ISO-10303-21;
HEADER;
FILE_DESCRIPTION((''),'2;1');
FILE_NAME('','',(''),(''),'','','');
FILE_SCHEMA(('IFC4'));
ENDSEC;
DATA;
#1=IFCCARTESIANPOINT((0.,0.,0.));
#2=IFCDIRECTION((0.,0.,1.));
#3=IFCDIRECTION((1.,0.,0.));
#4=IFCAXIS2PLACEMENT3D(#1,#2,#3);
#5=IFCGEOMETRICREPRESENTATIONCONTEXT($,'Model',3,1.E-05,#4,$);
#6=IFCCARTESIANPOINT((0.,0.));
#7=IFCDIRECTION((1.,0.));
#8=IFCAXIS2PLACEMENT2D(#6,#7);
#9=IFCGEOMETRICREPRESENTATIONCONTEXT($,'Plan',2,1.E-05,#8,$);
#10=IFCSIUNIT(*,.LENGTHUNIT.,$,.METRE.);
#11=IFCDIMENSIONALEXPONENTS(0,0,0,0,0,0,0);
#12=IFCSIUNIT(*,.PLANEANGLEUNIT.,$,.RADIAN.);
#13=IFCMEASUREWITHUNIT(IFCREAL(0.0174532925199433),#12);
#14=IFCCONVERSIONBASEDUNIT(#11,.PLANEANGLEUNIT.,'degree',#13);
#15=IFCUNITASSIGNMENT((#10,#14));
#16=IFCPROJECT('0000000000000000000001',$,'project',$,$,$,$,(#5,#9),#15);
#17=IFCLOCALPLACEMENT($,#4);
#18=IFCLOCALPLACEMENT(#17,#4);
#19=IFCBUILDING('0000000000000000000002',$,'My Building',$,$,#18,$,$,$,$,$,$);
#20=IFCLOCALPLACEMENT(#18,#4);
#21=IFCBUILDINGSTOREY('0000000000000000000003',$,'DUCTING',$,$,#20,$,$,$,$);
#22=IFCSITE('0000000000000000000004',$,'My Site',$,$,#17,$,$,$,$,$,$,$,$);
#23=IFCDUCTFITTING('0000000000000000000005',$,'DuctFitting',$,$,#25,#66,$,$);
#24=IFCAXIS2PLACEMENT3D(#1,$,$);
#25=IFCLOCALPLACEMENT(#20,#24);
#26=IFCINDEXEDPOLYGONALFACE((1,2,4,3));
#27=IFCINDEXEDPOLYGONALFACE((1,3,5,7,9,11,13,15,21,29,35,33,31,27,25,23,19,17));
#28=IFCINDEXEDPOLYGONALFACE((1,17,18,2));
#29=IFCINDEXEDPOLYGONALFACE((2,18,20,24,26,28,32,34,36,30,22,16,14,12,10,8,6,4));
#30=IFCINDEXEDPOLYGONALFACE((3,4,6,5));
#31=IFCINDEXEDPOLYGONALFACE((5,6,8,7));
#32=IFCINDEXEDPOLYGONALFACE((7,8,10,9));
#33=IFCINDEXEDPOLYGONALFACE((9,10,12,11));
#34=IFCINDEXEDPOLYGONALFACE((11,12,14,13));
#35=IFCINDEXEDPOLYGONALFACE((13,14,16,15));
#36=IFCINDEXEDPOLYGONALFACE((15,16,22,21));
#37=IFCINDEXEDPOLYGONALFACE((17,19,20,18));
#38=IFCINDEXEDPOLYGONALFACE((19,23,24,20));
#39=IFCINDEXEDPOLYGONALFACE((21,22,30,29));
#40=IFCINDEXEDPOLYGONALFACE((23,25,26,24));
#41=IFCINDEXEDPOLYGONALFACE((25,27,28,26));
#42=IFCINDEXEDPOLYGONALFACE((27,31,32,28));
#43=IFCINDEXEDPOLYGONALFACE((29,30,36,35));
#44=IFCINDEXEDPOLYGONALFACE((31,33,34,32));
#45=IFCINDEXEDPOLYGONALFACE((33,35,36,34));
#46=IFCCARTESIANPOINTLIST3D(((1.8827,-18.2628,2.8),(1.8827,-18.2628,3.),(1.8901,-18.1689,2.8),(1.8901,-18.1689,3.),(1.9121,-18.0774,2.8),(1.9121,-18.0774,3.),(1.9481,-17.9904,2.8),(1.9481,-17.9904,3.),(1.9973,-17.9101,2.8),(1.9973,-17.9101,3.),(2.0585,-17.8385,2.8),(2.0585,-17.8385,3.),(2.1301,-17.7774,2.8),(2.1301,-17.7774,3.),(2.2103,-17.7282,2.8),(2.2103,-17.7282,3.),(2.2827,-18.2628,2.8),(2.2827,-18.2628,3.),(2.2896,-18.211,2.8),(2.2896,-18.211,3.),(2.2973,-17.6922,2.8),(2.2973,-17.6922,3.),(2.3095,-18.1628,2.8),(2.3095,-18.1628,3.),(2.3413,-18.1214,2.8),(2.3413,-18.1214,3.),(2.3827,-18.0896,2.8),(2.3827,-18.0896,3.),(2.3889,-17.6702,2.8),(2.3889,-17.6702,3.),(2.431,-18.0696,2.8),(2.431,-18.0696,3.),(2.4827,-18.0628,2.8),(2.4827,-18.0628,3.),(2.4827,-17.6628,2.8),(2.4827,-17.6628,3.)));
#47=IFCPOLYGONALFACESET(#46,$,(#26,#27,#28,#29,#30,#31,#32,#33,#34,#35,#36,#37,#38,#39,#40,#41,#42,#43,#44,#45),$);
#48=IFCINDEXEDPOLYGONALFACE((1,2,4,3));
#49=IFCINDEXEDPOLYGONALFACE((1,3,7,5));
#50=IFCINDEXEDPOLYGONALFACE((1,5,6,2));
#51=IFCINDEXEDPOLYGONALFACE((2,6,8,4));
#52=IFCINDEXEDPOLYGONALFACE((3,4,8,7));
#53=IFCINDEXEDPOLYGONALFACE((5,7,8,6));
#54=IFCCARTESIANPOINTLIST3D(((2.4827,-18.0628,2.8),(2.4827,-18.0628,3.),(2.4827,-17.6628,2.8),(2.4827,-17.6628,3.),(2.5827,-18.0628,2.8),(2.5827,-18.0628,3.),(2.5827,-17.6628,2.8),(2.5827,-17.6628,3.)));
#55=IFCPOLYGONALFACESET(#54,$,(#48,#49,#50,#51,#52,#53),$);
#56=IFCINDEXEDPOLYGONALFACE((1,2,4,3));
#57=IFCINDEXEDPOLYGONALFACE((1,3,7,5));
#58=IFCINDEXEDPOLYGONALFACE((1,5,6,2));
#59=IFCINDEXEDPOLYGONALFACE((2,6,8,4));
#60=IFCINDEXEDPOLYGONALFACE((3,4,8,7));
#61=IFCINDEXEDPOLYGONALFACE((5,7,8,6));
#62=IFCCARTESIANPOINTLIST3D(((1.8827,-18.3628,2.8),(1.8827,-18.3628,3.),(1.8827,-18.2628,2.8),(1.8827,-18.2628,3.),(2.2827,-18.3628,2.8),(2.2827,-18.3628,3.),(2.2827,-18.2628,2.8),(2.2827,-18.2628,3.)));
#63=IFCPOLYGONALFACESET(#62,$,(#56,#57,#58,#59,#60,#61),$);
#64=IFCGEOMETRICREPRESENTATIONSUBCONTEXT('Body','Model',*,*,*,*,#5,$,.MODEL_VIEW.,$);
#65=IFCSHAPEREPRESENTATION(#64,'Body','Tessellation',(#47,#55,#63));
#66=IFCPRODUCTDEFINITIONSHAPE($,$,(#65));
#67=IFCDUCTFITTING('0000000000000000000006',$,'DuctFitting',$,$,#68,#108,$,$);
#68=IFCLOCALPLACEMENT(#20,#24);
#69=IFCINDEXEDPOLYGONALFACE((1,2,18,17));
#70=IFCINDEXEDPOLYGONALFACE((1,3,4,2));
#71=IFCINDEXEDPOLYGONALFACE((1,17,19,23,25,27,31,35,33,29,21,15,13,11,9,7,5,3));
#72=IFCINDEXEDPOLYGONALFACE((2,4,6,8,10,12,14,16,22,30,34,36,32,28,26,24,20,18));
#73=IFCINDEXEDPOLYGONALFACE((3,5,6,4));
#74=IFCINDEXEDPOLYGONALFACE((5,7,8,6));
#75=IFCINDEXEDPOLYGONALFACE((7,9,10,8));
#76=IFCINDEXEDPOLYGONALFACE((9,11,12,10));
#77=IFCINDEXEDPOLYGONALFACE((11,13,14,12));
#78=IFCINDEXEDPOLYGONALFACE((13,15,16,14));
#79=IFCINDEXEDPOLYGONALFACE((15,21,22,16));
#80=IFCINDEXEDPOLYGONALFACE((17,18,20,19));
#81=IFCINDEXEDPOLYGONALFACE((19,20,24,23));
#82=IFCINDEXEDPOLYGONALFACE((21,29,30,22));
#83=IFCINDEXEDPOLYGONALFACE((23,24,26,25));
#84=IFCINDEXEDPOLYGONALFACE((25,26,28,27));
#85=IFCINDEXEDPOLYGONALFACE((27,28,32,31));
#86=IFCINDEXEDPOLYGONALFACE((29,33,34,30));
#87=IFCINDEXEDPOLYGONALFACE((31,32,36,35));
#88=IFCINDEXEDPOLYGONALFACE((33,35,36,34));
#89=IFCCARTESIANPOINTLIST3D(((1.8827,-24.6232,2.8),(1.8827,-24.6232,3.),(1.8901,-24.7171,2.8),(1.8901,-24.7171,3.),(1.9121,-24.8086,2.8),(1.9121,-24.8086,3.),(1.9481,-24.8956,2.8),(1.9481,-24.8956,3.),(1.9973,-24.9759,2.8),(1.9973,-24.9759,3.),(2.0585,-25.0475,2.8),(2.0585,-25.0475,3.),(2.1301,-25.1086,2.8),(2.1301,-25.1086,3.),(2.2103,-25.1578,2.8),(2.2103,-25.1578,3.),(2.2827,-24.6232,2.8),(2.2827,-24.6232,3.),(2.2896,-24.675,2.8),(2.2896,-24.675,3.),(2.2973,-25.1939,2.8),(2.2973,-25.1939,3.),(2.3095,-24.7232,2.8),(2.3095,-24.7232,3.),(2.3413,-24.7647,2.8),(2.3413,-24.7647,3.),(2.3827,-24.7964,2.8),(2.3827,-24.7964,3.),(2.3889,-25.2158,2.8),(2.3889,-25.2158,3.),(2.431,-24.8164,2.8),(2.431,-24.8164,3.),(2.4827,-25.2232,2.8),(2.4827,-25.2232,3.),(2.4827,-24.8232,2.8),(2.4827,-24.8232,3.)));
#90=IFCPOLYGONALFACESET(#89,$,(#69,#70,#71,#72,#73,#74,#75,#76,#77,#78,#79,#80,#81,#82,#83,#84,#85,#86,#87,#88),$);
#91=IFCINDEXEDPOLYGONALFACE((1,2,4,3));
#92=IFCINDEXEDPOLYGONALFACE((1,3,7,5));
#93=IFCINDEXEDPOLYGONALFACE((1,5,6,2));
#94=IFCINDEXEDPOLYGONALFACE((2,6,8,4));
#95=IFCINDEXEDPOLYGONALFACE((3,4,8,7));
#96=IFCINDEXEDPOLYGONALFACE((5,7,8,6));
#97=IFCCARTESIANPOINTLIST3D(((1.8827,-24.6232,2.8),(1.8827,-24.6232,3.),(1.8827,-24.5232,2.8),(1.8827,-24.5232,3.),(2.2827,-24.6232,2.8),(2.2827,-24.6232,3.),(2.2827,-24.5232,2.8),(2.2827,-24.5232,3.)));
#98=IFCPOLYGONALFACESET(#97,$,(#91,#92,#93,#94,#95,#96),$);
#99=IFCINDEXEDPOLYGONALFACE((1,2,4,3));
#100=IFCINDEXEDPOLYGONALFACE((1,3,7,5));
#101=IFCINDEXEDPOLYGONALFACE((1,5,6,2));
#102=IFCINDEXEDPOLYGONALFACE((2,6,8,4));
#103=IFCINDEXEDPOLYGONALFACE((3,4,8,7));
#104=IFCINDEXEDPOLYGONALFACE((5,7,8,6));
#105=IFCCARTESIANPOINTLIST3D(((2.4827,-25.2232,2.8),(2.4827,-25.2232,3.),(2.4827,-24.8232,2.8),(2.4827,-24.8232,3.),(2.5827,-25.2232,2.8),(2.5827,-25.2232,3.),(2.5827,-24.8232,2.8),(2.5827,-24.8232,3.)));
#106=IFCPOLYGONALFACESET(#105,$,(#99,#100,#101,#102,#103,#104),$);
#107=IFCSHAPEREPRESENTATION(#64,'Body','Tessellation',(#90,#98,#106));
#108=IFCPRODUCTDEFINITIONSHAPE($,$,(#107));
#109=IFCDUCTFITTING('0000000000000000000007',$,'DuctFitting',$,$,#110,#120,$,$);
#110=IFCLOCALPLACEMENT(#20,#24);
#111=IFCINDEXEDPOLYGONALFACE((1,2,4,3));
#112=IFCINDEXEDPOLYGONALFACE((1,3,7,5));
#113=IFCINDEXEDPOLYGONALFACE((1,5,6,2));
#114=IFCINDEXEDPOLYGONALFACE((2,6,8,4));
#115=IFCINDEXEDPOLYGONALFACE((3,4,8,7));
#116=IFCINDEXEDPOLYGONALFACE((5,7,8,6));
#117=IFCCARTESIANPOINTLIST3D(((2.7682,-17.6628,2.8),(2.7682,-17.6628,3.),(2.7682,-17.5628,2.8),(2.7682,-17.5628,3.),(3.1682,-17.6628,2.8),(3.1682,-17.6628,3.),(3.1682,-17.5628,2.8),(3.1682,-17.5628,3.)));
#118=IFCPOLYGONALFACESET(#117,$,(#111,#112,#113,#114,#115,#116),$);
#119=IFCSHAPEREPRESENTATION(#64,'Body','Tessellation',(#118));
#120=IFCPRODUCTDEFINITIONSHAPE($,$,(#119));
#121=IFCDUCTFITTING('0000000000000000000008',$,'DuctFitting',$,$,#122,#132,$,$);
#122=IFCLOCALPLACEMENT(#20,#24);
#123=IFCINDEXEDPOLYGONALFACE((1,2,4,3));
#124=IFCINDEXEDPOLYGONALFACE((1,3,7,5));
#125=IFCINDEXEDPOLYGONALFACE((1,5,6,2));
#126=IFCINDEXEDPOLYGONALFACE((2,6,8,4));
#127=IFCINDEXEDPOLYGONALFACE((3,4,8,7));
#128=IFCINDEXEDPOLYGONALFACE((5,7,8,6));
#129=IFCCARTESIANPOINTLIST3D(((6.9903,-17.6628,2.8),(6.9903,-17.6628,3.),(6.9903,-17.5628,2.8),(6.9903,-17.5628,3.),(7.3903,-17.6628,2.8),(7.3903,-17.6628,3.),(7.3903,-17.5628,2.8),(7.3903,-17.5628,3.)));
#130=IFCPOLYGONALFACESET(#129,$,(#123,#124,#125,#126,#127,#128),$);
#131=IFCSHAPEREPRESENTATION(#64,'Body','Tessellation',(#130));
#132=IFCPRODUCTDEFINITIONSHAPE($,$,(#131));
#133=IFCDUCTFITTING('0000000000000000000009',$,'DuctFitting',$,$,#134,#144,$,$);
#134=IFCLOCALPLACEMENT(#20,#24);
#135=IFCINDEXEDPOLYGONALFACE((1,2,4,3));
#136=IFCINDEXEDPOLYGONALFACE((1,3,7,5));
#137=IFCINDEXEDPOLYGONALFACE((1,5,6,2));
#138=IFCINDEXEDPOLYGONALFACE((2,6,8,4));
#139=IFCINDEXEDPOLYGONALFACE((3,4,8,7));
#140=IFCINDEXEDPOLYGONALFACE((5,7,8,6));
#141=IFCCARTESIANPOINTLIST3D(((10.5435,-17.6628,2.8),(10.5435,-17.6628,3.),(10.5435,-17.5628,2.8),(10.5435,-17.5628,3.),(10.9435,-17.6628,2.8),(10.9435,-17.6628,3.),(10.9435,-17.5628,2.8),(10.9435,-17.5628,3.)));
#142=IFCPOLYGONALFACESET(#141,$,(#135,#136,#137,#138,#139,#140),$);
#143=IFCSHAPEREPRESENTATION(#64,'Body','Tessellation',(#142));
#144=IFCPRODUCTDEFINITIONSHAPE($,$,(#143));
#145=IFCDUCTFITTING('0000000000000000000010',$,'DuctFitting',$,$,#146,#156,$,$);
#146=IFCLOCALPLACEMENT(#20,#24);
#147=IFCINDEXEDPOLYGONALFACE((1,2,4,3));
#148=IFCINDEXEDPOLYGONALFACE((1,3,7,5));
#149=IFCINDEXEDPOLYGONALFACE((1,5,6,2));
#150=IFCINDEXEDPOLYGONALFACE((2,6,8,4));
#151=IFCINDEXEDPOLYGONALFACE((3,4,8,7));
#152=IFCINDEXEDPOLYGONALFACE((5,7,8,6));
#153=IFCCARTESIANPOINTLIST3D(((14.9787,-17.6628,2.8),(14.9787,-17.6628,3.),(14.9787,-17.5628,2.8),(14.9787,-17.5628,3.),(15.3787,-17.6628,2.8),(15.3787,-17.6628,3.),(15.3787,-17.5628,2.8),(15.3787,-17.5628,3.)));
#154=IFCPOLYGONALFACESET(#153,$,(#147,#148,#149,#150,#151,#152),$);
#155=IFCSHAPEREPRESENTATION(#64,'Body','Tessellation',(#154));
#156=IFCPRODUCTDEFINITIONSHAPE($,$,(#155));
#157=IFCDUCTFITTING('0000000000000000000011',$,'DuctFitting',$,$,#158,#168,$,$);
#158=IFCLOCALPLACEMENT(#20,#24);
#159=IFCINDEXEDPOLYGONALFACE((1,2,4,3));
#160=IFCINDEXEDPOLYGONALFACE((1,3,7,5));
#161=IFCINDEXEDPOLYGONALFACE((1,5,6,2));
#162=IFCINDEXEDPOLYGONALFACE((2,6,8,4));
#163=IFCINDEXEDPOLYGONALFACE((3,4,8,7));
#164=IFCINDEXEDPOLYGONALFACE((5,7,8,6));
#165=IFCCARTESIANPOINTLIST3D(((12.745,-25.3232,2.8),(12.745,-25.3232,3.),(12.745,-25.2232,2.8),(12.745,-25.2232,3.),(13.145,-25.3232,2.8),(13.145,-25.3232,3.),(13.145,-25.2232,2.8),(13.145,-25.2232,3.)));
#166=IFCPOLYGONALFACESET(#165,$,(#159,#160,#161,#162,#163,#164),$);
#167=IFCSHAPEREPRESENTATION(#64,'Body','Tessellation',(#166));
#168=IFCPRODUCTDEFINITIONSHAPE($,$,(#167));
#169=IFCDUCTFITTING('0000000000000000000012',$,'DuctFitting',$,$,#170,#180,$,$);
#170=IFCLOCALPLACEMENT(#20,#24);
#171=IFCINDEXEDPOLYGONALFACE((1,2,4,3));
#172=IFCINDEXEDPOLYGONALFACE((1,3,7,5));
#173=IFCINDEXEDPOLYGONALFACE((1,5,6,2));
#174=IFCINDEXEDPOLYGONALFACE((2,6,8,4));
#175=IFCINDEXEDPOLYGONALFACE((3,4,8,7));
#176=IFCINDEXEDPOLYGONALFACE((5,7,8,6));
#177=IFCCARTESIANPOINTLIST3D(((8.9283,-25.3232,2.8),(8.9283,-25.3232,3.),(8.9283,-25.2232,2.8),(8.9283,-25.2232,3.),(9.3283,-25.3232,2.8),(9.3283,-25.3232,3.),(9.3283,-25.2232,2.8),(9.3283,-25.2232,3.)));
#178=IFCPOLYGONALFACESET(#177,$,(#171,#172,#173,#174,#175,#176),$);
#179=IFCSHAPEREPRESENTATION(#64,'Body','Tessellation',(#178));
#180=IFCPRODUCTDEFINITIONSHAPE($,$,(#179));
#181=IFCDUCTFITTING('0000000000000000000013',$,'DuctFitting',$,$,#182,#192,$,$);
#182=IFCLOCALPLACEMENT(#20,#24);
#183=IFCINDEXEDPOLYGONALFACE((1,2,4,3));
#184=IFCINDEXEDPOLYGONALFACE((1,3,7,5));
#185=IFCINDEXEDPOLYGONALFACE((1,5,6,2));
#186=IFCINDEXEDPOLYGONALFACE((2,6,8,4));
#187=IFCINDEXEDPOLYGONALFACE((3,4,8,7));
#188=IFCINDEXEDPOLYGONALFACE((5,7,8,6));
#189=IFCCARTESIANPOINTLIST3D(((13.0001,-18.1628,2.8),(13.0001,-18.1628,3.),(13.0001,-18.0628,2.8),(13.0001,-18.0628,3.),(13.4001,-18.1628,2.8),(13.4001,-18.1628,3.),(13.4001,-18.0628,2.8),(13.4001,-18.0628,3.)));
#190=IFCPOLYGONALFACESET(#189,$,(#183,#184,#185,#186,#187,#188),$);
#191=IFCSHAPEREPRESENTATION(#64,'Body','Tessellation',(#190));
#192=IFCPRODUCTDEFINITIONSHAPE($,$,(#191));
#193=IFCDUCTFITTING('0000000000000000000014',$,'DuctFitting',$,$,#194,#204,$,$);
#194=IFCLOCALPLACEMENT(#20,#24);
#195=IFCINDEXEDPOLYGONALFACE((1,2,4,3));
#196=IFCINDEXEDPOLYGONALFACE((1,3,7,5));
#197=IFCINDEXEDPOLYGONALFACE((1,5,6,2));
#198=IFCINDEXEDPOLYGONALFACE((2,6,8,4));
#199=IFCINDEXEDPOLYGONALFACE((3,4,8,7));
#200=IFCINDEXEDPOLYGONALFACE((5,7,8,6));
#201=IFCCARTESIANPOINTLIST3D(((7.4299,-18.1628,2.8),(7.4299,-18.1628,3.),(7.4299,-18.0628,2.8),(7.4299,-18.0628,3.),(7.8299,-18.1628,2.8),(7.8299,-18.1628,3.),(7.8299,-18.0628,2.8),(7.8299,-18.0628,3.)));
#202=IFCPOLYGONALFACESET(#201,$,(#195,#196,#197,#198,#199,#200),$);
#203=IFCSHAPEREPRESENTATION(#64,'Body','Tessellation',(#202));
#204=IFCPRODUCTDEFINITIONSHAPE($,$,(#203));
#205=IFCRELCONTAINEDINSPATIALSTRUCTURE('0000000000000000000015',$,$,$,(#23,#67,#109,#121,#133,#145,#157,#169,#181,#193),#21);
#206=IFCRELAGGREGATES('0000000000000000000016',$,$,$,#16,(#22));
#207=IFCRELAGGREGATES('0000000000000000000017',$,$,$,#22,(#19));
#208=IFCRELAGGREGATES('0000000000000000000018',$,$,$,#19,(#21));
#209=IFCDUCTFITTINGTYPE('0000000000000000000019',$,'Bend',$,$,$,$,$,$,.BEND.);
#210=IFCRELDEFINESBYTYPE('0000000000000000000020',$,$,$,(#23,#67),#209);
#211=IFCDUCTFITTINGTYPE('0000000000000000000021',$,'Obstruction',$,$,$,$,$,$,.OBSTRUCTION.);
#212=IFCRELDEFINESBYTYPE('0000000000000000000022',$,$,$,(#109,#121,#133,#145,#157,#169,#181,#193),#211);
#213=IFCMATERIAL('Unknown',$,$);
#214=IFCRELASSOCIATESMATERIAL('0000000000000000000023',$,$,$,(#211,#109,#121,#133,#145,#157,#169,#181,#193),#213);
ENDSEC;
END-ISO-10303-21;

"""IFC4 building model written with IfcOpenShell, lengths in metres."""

from ifc_helpers import new_model, entity, si_unit, converted_unit, frame, origin_with_axes, origin_2d_with_axis, place, context, subcontext, project, spatial, line, arc, indexed_curve, rectangle, outline, extrude, source, transform, mapped, material, material_profile, profile_set, profile_usage, type_object, type_shapes, element, save


model = new_model("IFC4")

# Units and contexts
model_context = context("Model", 3, precision=1e-05, world=origin_with_axes())
plan_context = context("Plan", 2, precision=1e-05, world=origin_2d_with_axis())
body_context = subcontext(model_context, "Body", "Model", "MODEL_VIEW")
ifc_project = project(units=[si_unit("LENGTHUNIT", "METRE"), converted_unit("PLANEANGLEUNIT", "degree", entity("IfcReal", 0.0174532925199433), si_unit("PLANEANGLEUNIT", "RADIAN"), dimensions=[0, 0, 0, 0, 0, 0, 0])], contexts=[model_context, plan_context])

# Site, building, storey
site_placement = place(None, origin_with_axes())
site = spatial("IfcSite", under=ifc_project, at=site_placement, Name="My Site")
building_placement = place(site_placement, origin_with_axes())
building = spatial("IfcBuilding", under=site, at=building_placement, Name="My Building")
storey_placement = place(building_placement, origin_with_axes())
storey = spatial("IfcBuildingStorey", under=building, at=storey_placement, Name="DUCTING")

# Shared definitions
ifc_material = material(Name="Unknown")

# Duct fittings
duct_fitting_type_1 = type_object("IfcDuctFittingType", Name="Bend", PredefinedType="BEND")
shared_shape = source(origin_with_axes(), body_context, "Body", "SweptSolid", [
    extrude(outline(indexed_curve([(-0.2, 0.0), (-0.2586, -0.1414), (-0.4, -0.2), (-0.4, -0.6), (0.0243, -0.4243), (0.2, 0.0)], segments=[arc(1, 2, 3), line(3, 4), arc(4, 5, 6), line(6, 1)])), frame((0.0, -0.1, -0.1), z_axis=(0.0, -1.0, 0.0), x_axis=(1.0, 0.0, 0.0)), (0.0, 0.0, -1.0), 0.2),
    extrude(rectangle(XDim=0.4, YDim=0.2), origin_with_axes(), (0.0, 0.0, -1.0), 0.1),
    extrude(rectangle(XDim=0.4, YDim=0.2), frame((-0.4, 0.0, -0.5), z_axis=(-1.0, 0.0, 0.0), x_axis=(0.0, 0.0, -1.0)), (0.0, 0.0, 1.0), 0.1),
])
type_shapes(duct_fitting_type_1, [shared_shape])
for number, where, z_axis, x_axis, name in (
    (1, (2.5827, -17.8628, 2.9), (1.0, 0.0, 0.0), (0.0, 1.0, 0.0), "DuctFitting"),
    (2, (2.0827, -24.5232, 2.9), (0.0, 1.0, 0.0), (-1.0, 0.0, 0.0), "DuctFitting"),
):
    element("IfcDuctFitting", number, at=place(storey_placement, frame(where, z_axis=z_axis, x_axis=x_axis)), inside=storey, type_object=duct_fitting_type_1, Name=name, context=body_context, shape_type="MappedRepresentation", body=[
        mapped(shared_shape, transform((0.0, 0.0, 0.0), x_axis=(1.0, 0.0, 0.0), y_axis=(0.0, 1.0, 0.0), z_axis=(0.0, 0.0, 1.0), scale=1.0)),
    ])
ifc_material_profile_1 = material_profile(ifc_material, rectangle(XDim=0.4, YDim=0.2))
ifc_profile_set_1 = profile_set([ifc_material_profile_1])
ifc_profile_usage_1 = profile_usage(ifc_profile_set_1, cardinal=5)
duct_fitting_type_2 = type_object("IfcDuctFittingType", Name="Obstruction", PredefinedType="OBSTRUCTION", material=ifc_profile_set_1)
duct_fitting_1_placement = place(storey_placement, frame((2.9682, -17.6628, 2.9), z_axis=(0.0, 1.0, 0.0), x_axis=(-1.0, 0.0, 0.0)))
element("IfcDuctFitting", 3, at=duct_fitting_1_placement, inside=storey, type_object=duct_fitting_type_2, material=ifc_profile_usage_1, Name="DuctFitting", context=body_context, shape_type="SweptSolid", body=[
    extrude(rectangle(XDim=0.4, YDim=0.2), origin_with_axes(), (0.0, 0.0, 1.0), 0.1),
])
ifc_profile_usage_2 = profile_usage(ifc_profile_set_1, cardinal=5)
duct_fitting_2_placement = place(storey_placement, frame((7.1903, -17.6628, 2.9), z_axis=(0.0, 1.0, 0.0), x_axis=(-1.0, 0.0, 0.0)))
element("IfcDuctFitting", 4, at=duct_fitting_2_placement, inside=storey, type_object=duct_fitting_type_2, material=ifc_profile_usage_2, Name="DuctFitting", context=body_context, shape_type="SweptSolid", body=[
    extrude(rectangle(XDim=0.4, YDim=0.2), origin_with_axes(), (0.0, 0.0, 1.0), 0.1),
])
ifc_profile_usage_3 = profile_usage(ifc_profile_set_1, cardinal=5)
duct_fitting_3_placement = place(storey_placement, frame((10.7435, -17.6628, 2.9), z_axis=(0.0, 1.0, 0.0), x_axis=(-1.0, 0.0, 0.0)))
element("IfcDuctFitting", 5, at=duct_fitting_3_placement, inside=storey, type_object=duct_fitting_type_2, material=ifc_profile_usage_3, Name="DuctFitting", context=body_context, shape_type="SweptSolid", body=[
    extrude(rectangle(XDim=0.4, YDim=0.2), origin_with_axes(), (0.0, 0.0, 1.0), 0.1),
])
ifc_profile_usage_4 = profile_usage(ifc_profile_set_1, cardinal=5)
duct_fitting_4_placement = place(storey_placement, frame((15.1787, -17.6628, 2.9), z_axis=(0.0, 1.0, 0.0), x_axis=(-1.0, 0.0, 0.0)))
element("IfcDuctFitting", 6, at=duct_fitting_4_placement, inside=storey, type_object=duct_fitting_type_2, material=ifc_profile_usage_4, Name="DuctFitting", context=body_context, shape_type="SweptSolid", body=[
    extrude(rectangle(XDim=0.4, YDim=0.2), origin_with_axes(), (0.0, 0.0, 1.0), 0.1),
])
ifc_profile_usage_5 = profile_usage(ifc_profile_set_1, cardinal=5)
duct_fitting_5_placement = place(storey_placement, frame((12.945, -25.2232, 2.9), z_axis=(0.0, -1.0, 0.0), x_axis=(1.0, 0.0, 0.0)))
element("IfcDuctFitting", 7, at=duct_fitting_5_placement, inside=storey, type_object=duct_fitting_type_2, material=ifc_profile_usage_5, Name="DuctFitting", context=body_context, shape_type="SweptSolid", body=[
    extrude(rectangle(XDim=0.4, YDim=0.2), origin_with_axes(), (0.0, 0.0, 1.0), 0.1),
])
ifc_profile_usage_6 = profile_usage(ifc_profile_set_1, cardinal=5)
duct_fitting_6_placement = place(storey_placement, frame((9.1283, -25.2232, 2.9), z_axis=(0.0, -1.0, 0.0), x_axis=(1.0, 0.0, 0.0)))
element("IfcDuctFitting", 8, at=duct_fitting_6_placement, inside=storey, type_object=duct_fitting_type_2, material=ifc_profile_usage_6, Name="DuctFitting", context=body_context, shape_type="SweptSolid", body=[
    extrude(rectangle(XDim=0.4, YDim=0.2), origin_with_axes(), (0.0, 0.0, 1.0), 0.1),
])
ifc_profile_usage_7 = profile_usage(ifc_profile_set_1, cardinal=5)
duct_fitting_7_placement = place(storey_placement, frame((13.2001, -18.0628, 2.9), z_axis=(0.0, -1.0, 0.0), x_axis=(1.0, 0.0, 0.0)))
element("IfcDuctFitting", 9, at=duct_fitting_7_placement, inside=storey, type_object=duct_fitting_type_2, material=ifc_profile_usage_7, Name="DuctFitting", context=body_context, shape_type="SweptSolid", body=[
    extrude(rectangle(XDim=0.4, YDim=0.2), origin_with_axes(), (0.0, 0.0, 1.0), 0.1),
])
ifc_profile_usage_8 = profile_usage(ifc_profile_set_1, cardinal=5)
duct_fitting_8_placement = place(storey_placement, frame((7.6299, -18.0628, 2.9), z_axis=(0.0, -1.0, 0.0), x_axis=(1.0, 0.0, 0.0)))
element("IfcDuctFitting", 10, at=duct_fitting_8_placement, inside=storey, type_object=duct_fitting_type_2, material=ifc_profile_usage_8, Name="DuctFitting", context=body_context, shape_type="SweptSolid", body=[
    extrude(rectangle(XDim=0.4, YDim=0.2), origin_with_axes(), (0.0, 0.0, 1.0), 0.1),
])

save(model, "model.ifc")
